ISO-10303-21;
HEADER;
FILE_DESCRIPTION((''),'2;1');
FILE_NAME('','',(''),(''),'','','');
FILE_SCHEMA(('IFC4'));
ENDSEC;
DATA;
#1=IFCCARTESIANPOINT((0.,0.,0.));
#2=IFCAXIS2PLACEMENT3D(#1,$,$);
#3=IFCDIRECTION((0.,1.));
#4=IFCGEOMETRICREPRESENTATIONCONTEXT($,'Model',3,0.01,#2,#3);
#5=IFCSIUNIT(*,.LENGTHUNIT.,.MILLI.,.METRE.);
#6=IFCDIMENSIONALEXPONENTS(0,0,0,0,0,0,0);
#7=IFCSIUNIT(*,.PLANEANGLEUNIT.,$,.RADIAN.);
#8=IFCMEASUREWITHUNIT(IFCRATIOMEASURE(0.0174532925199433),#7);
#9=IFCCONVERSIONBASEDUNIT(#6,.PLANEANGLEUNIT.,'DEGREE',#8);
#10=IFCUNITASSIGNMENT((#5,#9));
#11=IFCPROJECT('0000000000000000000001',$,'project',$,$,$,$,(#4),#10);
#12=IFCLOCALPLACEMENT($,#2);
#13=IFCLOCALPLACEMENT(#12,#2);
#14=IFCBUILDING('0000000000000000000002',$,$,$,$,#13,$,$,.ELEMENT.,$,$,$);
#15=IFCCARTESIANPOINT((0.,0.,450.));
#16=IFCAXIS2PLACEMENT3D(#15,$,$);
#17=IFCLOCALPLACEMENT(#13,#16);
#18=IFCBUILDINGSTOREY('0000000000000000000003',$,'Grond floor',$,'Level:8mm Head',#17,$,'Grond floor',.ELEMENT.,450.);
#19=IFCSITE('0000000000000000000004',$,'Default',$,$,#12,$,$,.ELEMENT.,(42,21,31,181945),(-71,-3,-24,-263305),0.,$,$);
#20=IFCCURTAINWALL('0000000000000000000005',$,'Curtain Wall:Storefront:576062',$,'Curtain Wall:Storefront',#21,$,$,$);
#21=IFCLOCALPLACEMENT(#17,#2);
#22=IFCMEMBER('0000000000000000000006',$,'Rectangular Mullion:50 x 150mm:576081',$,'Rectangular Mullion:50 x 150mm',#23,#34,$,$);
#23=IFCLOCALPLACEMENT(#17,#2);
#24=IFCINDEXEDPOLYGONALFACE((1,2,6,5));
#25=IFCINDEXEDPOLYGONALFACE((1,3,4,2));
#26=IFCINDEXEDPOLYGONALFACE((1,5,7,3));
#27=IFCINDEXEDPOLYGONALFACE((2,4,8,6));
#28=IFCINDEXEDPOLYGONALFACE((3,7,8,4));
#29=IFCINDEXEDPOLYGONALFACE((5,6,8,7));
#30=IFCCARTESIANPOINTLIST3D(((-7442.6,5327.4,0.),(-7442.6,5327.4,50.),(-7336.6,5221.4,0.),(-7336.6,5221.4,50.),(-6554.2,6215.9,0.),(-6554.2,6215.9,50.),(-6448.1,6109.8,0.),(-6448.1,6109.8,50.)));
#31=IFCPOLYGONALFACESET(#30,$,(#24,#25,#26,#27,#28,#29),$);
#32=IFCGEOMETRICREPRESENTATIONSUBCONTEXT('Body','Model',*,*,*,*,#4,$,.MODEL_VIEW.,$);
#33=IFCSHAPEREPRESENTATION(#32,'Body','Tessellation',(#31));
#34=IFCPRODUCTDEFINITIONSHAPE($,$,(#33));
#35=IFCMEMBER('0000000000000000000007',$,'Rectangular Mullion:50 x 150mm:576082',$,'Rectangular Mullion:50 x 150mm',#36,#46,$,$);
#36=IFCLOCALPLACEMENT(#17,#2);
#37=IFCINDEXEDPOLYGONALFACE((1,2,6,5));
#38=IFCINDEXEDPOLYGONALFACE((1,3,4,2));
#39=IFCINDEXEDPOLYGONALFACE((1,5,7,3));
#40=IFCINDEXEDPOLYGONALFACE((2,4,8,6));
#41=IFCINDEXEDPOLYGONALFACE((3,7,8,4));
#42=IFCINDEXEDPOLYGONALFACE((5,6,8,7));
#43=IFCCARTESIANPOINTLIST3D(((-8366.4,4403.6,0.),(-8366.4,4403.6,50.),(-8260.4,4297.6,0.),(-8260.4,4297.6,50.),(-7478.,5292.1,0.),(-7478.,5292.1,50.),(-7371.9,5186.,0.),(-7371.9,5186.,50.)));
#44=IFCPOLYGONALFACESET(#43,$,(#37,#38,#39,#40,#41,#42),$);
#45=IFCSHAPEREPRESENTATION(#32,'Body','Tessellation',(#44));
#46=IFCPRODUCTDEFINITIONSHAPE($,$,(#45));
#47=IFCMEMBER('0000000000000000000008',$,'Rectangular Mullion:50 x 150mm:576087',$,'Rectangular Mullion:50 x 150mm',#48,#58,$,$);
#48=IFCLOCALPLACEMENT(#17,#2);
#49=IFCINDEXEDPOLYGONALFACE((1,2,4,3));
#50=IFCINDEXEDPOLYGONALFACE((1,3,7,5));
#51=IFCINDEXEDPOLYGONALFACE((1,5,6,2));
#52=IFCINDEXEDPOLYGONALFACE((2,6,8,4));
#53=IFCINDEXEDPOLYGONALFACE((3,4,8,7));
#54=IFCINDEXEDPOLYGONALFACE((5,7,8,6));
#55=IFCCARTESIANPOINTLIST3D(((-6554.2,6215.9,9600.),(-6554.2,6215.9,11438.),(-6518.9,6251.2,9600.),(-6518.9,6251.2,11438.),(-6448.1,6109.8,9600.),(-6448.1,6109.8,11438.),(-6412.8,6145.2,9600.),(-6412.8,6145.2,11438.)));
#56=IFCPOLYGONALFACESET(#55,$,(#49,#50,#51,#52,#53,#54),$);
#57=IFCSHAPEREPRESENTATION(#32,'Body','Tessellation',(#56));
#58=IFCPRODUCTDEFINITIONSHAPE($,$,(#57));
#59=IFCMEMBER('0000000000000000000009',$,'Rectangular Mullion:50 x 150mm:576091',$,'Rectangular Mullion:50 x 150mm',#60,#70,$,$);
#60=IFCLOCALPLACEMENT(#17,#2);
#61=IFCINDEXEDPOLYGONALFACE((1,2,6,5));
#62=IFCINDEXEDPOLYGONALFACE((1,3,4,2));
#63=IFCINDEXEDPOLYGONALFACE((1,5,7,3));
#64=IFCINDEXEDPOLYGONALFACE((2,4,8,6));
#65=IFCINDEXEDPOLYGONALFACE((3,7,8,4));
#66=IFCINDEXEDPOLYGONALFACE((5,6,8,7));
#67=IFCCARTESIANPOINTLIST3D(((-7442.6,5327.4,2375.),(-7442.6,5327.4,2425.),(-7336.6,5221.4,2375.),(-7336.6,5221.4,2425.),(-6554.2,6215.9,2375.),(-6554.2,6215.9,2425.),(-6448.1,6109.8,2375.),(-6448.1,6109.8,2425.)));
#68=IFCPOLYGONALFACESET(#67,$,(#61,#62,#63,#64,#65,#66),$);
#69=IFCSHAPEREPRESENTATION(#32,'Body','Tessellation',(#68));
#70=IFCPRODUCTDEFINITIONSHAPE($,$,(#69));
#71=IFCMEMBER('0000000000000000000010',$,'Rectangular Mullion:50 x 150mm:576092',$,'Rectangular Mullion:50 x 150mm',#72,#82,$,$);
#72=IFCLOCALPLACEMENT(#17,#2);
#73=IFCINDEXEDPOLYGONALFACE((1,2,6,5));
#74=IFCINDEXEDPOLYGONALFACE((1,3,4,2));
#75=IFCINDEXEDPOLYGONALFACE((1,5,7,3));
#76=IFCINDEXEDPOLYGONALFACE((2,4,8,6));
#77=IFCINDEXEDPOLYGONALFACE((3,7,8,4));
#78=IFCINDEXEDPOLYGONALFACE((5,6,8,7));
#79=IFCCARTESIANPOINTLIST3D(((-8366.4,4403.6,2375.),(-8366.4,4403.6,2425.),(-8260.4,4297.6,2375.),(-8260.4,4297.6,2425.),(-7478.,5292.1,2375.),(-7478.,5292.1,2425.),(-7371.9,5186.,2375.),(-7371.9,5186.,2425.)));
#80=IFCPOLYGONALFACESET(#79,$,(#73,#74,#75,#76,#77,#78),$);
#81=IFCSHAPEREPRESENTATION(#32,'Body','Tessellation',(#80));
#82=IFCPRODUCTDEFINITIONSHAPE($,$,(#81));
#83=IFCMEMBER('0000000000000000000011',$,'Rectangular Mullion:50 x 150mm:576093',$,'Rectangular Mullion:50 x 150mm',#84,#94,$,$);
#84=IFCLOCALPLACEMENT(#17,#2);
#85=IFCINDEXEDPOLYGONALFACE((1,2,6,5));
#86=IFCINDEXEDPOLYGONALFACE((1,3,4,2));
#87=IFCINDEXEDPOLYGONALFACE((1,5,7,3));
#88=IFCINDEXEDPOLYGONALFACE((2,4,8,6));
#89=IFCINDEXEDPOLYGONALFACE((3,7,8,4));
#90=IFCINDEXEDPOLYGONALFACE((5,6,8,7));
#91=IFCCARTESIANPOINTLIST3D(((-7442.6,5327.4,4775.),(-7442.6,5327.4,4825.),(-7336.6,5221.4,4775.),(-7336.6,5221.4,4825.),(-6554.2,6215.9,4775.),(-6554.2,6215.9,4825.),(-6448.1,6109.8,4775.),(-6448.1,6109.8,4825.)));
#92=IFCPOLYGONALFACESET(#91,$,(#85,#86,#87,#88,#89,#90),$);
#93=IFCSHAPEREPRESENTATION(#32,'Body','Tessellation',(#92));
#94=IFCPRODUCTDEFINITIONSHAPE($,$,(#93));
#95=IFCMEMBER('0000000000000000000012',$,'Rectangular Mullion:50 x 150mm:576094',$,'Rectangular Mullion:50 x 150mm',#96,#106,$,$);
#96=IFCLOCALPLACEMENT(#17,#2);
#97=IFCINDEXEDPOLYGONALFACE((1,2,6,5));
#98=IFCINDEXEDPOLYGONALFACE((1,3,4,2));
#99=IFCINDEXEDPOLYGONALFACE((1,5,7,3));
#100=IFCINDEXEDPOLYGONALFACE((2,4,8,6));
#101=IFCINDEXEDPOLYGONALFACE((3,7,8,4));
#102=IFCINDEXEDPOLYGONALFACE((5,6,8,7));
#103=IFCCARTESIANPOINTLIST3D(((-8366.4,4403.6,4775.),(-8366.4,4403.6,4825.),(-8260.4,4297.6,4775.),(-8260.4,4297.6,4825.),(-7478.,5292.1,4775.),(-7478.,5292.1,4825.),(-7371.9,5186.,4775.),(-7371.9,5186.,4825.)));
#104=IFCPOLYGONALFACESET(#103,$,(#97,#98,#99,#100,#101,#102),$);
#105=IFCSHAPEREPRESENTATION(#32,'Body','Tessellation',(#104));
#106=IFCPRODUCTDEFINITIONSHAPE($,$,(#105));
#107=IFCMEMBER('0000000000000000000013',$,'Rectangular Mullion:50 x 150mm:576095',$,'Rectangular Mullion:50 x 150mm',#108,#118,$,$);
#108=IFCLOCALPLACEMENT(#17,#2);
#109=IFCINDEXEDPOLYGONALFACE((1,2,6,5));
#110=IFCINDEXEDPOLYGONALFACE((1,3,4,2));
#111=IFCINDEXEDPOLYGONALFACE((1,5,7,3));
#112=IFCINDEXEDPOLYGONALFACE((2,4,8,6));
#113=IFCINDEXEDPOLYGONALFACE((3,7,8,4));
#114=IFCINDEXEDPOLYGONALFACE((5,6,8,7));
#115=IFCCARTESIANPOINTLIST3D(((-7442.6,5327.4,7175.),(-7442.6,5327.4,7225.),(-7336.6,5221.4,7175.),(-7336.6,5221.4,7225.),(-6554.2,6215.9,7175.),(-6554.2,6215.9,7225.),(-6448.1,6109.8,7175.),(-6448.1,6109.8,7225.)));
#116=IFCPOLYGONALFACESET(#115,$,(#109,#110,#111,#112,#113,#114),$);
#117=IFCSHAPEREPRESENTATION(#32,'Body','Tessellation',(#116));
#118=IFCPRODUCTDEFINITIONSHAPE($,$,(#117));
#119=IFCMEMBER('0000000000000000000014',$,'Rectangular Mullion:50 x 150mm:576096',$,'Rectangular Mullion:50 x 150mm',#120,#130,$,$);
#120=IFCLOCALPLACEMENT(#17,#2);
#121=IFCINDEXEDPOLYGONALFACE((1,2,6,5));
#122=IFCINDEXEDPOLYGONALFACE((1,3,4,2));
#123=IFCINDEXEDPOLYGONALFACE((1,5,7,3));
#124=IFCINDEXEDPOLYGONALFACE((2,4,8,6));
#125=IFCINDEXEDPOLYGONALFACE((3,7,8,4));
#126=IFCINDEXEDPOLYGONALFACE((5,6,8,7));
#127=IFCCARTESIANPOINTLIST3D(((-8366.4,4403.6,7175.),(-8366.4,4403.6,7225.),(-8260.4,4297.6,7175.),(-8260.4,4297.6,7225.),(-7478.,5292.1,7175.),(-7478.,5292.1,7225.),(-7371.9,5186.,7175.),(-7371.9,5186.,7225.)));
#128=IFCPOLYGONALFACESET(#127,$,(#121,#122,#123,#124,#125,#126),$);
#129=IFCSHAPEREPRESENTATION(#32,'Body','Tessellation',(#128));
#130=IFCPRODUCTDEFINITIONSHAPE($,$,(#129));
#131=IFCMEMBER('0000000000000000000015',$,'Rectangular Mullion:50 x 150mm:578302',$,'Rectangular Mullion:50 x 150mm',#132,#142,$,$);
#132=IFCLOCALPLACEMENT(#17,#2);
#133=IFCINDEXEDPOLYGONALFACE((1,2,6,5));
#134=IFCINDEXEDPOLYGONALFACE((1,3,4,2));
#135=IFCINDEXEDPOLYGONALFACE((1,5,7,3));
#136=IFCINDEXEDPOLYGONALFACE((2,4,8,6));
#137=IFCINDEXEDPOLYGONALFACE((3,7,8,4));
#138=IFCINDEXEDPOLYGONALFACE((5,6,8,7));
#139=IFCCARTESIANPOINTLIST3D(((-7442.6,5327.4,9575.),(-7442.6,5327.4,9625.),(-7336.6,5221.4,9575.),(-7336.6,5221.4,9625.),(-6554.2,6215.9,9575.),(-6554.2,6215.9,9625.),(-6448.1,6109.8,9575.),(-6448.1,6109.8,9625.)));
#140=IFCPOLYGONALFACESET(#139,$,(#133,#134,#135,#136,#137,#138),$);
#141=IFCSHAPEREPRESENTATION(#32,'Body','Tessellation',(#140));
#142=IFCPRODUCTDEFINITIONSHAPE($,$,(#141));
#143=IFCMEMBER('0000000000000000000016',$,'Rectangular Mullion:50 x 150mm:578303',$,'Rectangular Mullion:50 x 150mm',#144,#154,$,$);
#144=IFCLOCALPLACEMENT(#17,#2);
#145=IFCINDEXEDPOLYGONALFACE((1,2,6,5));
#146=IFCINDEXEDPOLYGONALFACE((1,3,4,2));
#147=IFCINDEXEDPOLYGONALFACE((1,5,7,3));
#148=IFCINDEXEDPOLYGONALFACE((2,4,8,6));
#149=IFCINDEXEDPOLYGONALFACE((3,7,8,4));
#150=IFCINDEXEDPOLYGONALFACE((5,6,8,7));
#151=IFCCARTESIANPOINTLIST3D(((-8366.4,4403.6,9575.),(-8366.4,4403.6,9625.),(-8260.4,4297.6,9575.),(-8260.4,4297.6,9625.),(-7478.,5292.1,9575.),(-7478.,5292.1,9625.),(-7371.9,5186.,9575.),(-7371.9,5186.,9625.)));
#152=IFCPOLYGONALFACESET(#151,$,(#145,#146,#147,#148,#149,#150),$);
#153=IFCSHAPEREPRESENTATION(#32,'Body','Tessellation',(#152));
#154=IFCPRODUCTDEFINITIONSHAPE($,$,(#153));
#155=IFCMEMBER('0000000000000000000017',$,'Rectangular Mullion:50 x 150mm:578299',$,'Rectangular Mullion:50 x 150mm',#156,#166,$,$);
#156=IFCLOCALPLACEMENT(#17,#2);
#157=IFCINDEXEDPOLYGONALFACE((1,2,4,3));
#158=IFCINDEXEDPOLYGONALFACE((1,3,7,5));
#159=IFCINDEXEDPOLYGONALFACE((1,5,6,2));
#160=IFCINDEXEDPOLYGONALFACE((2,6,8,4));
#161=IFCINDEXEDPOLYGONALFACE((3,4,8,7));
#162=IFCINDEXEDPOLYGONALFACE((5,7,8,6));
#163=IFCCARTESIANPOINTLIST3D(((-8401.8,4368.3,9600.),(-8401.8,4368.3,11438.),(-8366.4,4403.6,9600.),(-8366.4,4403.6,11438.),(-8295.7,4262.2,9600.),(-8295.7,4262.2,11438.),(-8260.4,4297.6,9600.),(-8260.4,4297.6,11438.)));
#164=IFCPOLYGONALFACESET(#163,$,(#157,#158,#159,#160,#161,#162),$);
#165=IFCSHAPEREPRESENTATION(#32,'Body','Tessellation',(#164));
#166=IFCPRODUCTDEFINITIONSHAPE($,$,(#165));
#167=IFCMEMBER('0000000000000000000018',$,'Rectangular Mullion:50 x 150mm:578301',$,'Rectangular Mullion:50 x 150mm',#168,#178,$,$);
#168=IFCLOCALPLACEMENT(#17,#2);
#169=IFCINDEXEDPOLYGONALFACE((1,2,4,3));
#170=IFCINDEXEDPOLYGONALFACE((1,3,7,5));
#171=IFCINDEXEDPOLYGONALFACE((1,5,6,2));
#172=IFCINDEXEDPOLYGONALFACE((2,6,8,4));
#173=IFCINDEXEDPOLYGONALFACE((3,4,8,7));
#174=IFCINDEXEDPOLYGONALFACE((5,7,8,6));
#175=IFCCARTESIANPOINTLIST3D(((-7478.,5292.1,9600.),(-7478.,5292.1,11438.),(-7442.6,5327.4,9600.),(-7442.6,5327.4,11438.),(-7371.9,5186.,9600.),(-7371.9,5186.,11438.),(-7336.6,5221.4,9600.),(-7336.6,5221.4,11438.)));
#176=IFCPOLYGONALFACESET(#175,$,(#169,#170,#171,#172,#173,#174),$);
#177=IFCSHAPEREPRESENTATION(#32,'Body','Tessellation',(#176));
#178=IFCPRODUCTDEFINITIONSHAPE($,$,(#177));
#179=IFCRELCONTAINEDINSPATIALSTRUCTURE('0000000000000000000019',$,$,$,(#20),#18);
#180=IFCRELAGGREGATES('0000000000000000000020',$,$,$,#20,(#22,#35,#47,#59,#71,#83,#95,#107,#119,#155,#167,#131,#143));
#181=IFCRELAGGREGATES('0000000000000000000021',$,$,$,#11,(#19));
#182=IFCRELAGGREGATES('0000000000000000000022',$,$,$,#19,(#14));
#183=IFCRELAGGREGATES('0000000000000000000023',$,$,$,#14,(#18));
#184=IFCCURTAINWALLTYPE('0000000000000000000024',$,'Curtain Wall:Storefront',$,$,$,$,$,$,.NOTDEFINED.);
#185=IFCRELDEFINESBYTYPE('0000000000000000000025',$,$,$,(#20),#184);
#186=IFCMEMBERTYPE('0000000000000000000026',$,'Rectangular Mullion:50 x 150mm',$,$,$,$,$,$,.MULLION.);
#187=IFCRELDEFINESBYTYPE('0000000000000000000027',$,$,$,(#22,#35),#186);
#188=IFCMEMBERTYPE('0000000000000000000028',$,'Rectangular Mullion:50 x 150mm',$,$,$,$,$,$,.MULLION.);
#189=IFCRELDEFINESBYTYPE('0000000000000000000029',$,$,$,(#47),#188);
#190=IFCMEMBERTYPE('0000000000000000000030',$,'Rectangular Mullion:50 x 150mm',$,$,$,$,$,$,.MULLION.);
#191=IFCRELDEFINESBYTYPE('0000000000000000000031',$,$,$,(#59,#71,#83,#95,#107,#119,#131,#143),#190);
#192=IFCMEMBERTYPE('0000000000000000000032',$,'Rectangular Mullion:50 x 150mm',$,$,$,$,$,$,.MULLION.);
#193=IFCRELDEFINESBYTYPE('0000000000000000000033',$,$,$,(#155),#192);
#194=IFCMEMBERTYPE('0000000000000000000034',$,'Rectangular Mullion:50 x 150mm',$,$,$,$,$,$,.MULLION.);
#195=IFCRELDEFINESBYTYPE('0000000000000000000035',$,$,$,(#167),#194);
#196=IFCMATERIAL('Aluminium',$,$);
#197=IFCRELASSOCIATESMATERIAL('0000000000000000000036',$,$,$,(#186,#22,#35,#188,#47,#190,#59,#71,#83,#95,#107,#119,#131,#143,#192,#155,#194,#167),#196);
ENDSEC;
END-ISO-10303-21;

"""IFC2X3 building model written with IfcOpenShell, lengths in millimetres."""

from ifc_helpers import new_model, entity, si_unit, converted_unit, direction, frame, origin, origin_2d_with_axis, place, context, subcontext, project, spatial, rectangle, extrude, source, transform, mapped, material, type_object, type_shapes, element, aggregate, save


model = new_model("IFC2X3")

# Units and contexts
model_context = context("Model", 3, precision=0.01, world=origin(), true_north=direction((0.0, 1.0)))
body_context = subcontext(model_context, "Body", "Model", "MODEL_VIEW")
ifc_project = project(units=[si_unit("LENGTHUNIT", "METRE", prefix="MILLI"), converted_unit("PLANEANGLEUNIT", "DEGREE", entity("IfcRatioMeasure", 0.0174532925199433), si_unit("PLANEANGLEUNIT", "RADIAN"), dimensions=[0, 0, 0, 0, 0, 0, 0])], contexts=[model_context])

# Site, building, storey
site_placement = place(None, origin())
site = spatial("IfcSite", under=ifc_project, at=site_placement, Name="Default", CompositionType="ELEMENT", RefLatitude=(42, 21, 31, 181945), RefLongitude=(-71, -3, -24, -263305), RefElevation=0.0)
building_placement = place(site_placement, origin())
building = spatial("IfcBuilding", under=site, at=building_placement, CompositionType="ELEMENT")
storey_placement = place(building_placement, frame((0.0, 0.0, 450.0)))
storey = spatial("IfcBuildingStorey", under=building, at=storey_placement, Name="Grond floor", ObjectType="Level:8mm Head", LongName="Grond floor", CompositionType="ELEMENT", Elevation=450.0)

# Curtain wall, members
curtain_wall_type = type_object("IfcCurtainWallType", Name="Curtain Wall:Storefront", PredefinedType="NOTDEFINED")
curtain_wall_placement = place(storey_placement, frame((0.0, 0.0, -450.0)))
curtain_wall = element("IfcCurtainWall", 1, at=curtain_wall_placement, inside=storey, type_object=curtain_wall_type, Name="Curtain Wall:Storefront:576062", ObjectType="Curtain Wall:Storefront")
ifc_material_1 = material(Name="Aluminium")
member_type_1 = type_object("IfcMemberType", Name="Rectangular Mullion:50 x 150mm", PredefinedType="MULLION", material=ifc_material_1)
shared_shape_1 = source(origin(), body_context, "Body", "SweptSolid", [
    extrude(rectangle(XDim=150.0, YDim=50.0, at=origin_2d_with_axis()), frame((-25.0, 0.0, -1256.4), z_axis=(0.0, 0.0, 1.0), x_axis=(0.0, -1.0, 0.0)), (0.0, 0.0, 1.0), 1256.4),
])
type_shapes(member_type_1, [shared_shape_1])
member_1_placement = place(storey_placement, frame((-6501.2, 6162.8, 0.0), z_axis=(0.707107, 0.707107, 0.0), x_axis=(0.0, 0.0, -1.0)))
member_1 = element("IfcMember", 2, at=member_1_placement, type_object=member_type_1, material=ifc_material_1, Name="Rectangular Mullion:50 x 150mm:576081", ObjectType="Rectangular Mullion:50 x 150mm", context=body_context, shape_type="MappedRepresentation", body=[
    mapped(shared_shape_1, transform((0.0, 0.0, 0.0), scale=1.0)),
])
member_2_placement = place(storey_placement, frame((-7425.0, 5239.0, 0.0), z_axis=(0.707107, 0.707107, 0.0), x_axis=(0.0, 0.0, -1.0)))
member_2 = element("IfcMember", 3, at=member_2_placement, type_object=member_type_1, material=ifc_material_1, Name="Rectangular Mullion:50 x 150mm:576082", ObjectType="Rectangular Mullion:50 x 150mm", context=body_context, shape_type="MappedRepresentation", body=[
    mapped(shared_shape_1, transform((0.0, 0.0, 0.0), scale=1.0)),
])
member_type_2 = type_object("IfcMemberType", Name="Rectangular Mullion:50 x 150mm", PredefinedType="MULLION", material=ifc_material_1)
shared_shape_2 = source(origin(), body_context, "Body", "SweptSolid", [
    extrude(rectangle(XDim=150.0, YDim=50.0, at=origin_2d_with_axis()), frame((-25.0, 0.0, -1838.0), z_axis=(0.0, 0.0, 1.0), x_axis=(0.0, -1.0, 0.0)), (0.0, 0.0, 1.0), 1838.0),
])
type_shapes(member_type_2, [shared_shape_2])
member_3_placement = place(storey_placement, frame((-6465.8, 6198.2, 11438.0), z_axis=(0.0, 0.0, 1.0), x_axis=(0.707107, 0.707107, 0.0)))
member_3 = element("IfcMember", 4, at=member_3_placement, type_object=member_type_2, material=ifc_material_1, Name="Rectangular Mullion:50 x 150mm:576087", ObjectType="Rectangular Mullion:50 x 150mm", context=body_context, shape_type="MappedRepresentation", body=[
    mapped(shared_shape_2, transform((0.0, 0.0, 0.0), scale=1.0)),
])
member_type_3 = type_object("IfcMemberType", Name="Rectangular Mullion:50 x 150mm", PredefinedType="MULLION", material=ifc_material_1)
shared_shape_3 = source(origin(), body_context, "Body", "SweptSolid", [
    extrude(rectangle(XDim=150.0, YDim=50.0, at=origin_2d_with_axis()), frame((0.0, 0.0, -1256.4), z_axis=(0.0, 0.0, 1.0), x_axis=(0.0, -1.0, 0.0)), (0.0, 0.0, 1.0), 1256.4),
])
type_shapes(member_type_3, [shared_shape_3])
member_4_placement = place(storey_placement, frame((-7389.6, 5274.4, 2400.0), z_axis=(-0.707107, -0.707107, 0.0), x_axis=(0.0, 0.0, 1.0)))
member_4 = element("IfcMember", 5, at=member_4_placement, type_object=member_type_3, material=ifc_material_1, Name="Rectangular Mullion:50 x 150mm:576091", ObjectType="Rectangular Mullion:50 x 150mm", context=body_context, shape_type="MappedRepresentation", body=[
    mapped(shared_shape_3, transform((0.0, 0.0, 0.0), scale=1.0)),
])
member_5_placement = place(storey_placement, frame((-8313.4, 4350.6, 2400.0), z_axis=(-0.707107, -0.707107, 0.0), x_axis=(0.0, 0.0, 1.0)))
member_5 = element("IfcMember", 6, at=member_5_placement, type_object=member_type_3, material=ifc_material_1, Name="Rectangular Mullion:50 x 150mm:576092", ObjectType="Rectangular Mullion:50 x 150mm", context=body_context, shape_type="MappedRepresentation", body=[
    mapped(shared_shape_3, transform((0.0, 0.0, 0.0), scale=1.0)),
])
member_6_placement = place(storey_placement, frame((-7389.6, 5274.4, 4800.0), z_axis=(-0.707107, -0.707107, 0.0), x_axis=(0.0, 0.0, 1.0)))
member_6 = element("IfcMember", 7, at=member_6_placement, type_object=member_type_3, material=ifc_material_1, Name="Rectangular Mullion:50 x 150mm:576093", ObjectType="Rectangular Mullion:50 x 150mm", context=body_context, shape_type="MappedRepresentation", body=[
    mapped(shared_shape_3, transform((0.0, 0.0, 0.0), scale=1.0)),
])
member_7_placement = place(storey_placement, frame((-8313.4, 4350.6, 4800.0), z_axis=(-0.707107, -0.707107, 0.0), x_axis=(0.0, 0.0, 1.0)))
member_7 = element("IfcMember", 8, at=member_7_placement, type_object=member_type_3, material=ifc_material_1, Name="Rectangular Mullion:50 x 150mm:576094", ObjectType="Rectangular Mullion:50 x 150mm", context=body_context, shape_type="MappedRepresentation", body=[
    mapped(shared_shape_3, transform((0.0, 0.0, 0.0), scale=1.0)),
])
member_8_placement = place(storey_placement, frame((-7389.6, 5274.4, 7200.0), z_axis=(-0.707107, -0.707107, 0.0), x_axis=(0.0, 0.0, 1.0)))
member_8 = element("IfcMember", 9, at=member_8_placement, type_object=member_type_3, material=ifc_material_1, Name="Rectangular Mullion:50 x 150mm:576095", ObjectType="Rectangular Mullion:50 x 150mm", context=body_context, shape_type="MappedRepresentation", body=[
    mapped(shared_shape_3, transform((0.0, 0.0, 0.0), scale=1.0)),
])
member_9_placement = place(storey_placement, frame((-8313.4, 4350.6, 7200.0), z_axis=(-0.707107, -0.707107, 0.0), x_axis=(0.0, 0.0, 1.0)))
member_9 = element("IfcMember", 10, at=member_9_placement, type_object=member_type_3, material=ifc_material_1, Name="Rectangular Mullion:50 x 150mm:576096", ObjectType="Rectangular Mullion:50 x 150mm", context=body_context, shape_type="MappedRepresentation", body=[
    mapped(shared_shape_3, transform((0.0, 0.0, 0.0), scale=1.0)),
])
member_10_placement = place(storey_placement, frame((-7389.6, 5274.4, 9600.0), z_axis=(-0.707107, -0.707107, 0.0), x_axis=(0.0, 0.0, 1.0)))
member_10 = element("IfcMember", 11, at=member_10_placement, type_object=member_type_3, material=ifc_material_1, Name="Rectangular Mullion:50 x 150mm:578302", ObjectType="Rectangular Mullion:50 x 150mm", context=body_context, shape_type="MappedRepresentation", body=[
    mapped(shared_shape_3, transform((0.0, 0.0, 0.0), scale=1.0)),
])
member_11_placement = place(storey_placement, frame((-8313.4, 4350.6, 9600.0), z_axis=(-0.707107, -0.707107, 0.0), x_axis=(0.0, 0.0, 1.0)))
member_11 = element("IfcMember", 12, at=member_11_placement, type_object=member_type_3, material=ifc_material_1, Name="Rectangular Mullion:50 x 150mm:578303", ObjectType="Rectangular Mullion:50 x 150mm", context=body_context, shape_type="MappedRepresentation", body=[
    mapped(shared_shape_3, transform((0.0, 0.0, 0.0), scale=1.0)),
])
member_type_4 = type_object("IfcMemberType", Name="Rectangular Mullion:50 x 150mm", PredefinedType="MULLION", material=ifc_material_1)
shared_shape_4 = source(origin(), body_context, "Body", "SweptSolid", [
    extrude(rectangle(XDim=150.0, YDim=50.0, at=origin_2d_with_axis()), frame((-25.0, 0.0, -1838.0), z_axis=(0.0, 0.0, 1.0), x_axis=(0.0, -1.0, 0.0)), (0.0, 0.0, 1.0), 1838.0),
])
type_shapes(member_type_4, [shared_shape_4])
member_12_placement = place(storey_placement, frame((-8348.8, 4315.3, 9600.0), z_axis=(0.0, 0.0, -1.0), x_axis=(-0.707107, -0.707107, 0.0)))
member_12 = element("IfcMember", 13, at=member_12_placement, type_object=member_type_4, material=ifc_material_1, Name="Rectangular Mullion:50 x 150mm:578299", ObjectType="Rectangular Mullion:50 x 150mm", context=body_context, shape_type="MappedRepresentation", body=[
    mapped(shared_shape_4, transform((0.0, 0.0, 0.0), scale=1.0)),
])
member_type_5 = type_object("IfcMemberType", Name="Rectangular Mullion:50 x 150mm", PredefinedType="MULLION", material=ifc_material_1)
shared_shape_5 = source(origin(), body_context, "Body", "SweptSolid", [
    extrude(rectangle(XDim=150.0, YDim=50.0, at=origin_2d_with_axis()), frame((0.0, 0.0, -1838.0), z_axis=(0.0, 0.0, 1.0), x_axis=(0.0, -1.0, 0.0)), (0.0, 0.0, 1.0), 1838.0),
])
type_shapes(member_type_5, [shared_shape_5])
member_13_placement = place(storey_placement, frame((-7407.3, 5256.7, 9600.0), z_axis=(0.0, 0.0, -1.0), x_axis=(-0.707107, -0.707107, 0.0)))
member_13 = element("IfcMember", 14, at=member_13_placement, type_object=member_type_5, material=ifc_material_1, Name="Rectangular Mullion:50 x 150mm:578301", ObjectType="Rectangular Mullion:50 x 150mm", context=body_context, shape_type="MappedRepresentation", body=[
    mapped(shared_shape_5, transform((0.0, 0.0, 0.0), scale=1.0)),
])
aggregate(curtain_wall, [member_1, member_2, member_3, member_4, member_5, member_6, member_7, member_8, member_9, member_12, member_13, member_10, member_11])

save(model, "model.ifc")
